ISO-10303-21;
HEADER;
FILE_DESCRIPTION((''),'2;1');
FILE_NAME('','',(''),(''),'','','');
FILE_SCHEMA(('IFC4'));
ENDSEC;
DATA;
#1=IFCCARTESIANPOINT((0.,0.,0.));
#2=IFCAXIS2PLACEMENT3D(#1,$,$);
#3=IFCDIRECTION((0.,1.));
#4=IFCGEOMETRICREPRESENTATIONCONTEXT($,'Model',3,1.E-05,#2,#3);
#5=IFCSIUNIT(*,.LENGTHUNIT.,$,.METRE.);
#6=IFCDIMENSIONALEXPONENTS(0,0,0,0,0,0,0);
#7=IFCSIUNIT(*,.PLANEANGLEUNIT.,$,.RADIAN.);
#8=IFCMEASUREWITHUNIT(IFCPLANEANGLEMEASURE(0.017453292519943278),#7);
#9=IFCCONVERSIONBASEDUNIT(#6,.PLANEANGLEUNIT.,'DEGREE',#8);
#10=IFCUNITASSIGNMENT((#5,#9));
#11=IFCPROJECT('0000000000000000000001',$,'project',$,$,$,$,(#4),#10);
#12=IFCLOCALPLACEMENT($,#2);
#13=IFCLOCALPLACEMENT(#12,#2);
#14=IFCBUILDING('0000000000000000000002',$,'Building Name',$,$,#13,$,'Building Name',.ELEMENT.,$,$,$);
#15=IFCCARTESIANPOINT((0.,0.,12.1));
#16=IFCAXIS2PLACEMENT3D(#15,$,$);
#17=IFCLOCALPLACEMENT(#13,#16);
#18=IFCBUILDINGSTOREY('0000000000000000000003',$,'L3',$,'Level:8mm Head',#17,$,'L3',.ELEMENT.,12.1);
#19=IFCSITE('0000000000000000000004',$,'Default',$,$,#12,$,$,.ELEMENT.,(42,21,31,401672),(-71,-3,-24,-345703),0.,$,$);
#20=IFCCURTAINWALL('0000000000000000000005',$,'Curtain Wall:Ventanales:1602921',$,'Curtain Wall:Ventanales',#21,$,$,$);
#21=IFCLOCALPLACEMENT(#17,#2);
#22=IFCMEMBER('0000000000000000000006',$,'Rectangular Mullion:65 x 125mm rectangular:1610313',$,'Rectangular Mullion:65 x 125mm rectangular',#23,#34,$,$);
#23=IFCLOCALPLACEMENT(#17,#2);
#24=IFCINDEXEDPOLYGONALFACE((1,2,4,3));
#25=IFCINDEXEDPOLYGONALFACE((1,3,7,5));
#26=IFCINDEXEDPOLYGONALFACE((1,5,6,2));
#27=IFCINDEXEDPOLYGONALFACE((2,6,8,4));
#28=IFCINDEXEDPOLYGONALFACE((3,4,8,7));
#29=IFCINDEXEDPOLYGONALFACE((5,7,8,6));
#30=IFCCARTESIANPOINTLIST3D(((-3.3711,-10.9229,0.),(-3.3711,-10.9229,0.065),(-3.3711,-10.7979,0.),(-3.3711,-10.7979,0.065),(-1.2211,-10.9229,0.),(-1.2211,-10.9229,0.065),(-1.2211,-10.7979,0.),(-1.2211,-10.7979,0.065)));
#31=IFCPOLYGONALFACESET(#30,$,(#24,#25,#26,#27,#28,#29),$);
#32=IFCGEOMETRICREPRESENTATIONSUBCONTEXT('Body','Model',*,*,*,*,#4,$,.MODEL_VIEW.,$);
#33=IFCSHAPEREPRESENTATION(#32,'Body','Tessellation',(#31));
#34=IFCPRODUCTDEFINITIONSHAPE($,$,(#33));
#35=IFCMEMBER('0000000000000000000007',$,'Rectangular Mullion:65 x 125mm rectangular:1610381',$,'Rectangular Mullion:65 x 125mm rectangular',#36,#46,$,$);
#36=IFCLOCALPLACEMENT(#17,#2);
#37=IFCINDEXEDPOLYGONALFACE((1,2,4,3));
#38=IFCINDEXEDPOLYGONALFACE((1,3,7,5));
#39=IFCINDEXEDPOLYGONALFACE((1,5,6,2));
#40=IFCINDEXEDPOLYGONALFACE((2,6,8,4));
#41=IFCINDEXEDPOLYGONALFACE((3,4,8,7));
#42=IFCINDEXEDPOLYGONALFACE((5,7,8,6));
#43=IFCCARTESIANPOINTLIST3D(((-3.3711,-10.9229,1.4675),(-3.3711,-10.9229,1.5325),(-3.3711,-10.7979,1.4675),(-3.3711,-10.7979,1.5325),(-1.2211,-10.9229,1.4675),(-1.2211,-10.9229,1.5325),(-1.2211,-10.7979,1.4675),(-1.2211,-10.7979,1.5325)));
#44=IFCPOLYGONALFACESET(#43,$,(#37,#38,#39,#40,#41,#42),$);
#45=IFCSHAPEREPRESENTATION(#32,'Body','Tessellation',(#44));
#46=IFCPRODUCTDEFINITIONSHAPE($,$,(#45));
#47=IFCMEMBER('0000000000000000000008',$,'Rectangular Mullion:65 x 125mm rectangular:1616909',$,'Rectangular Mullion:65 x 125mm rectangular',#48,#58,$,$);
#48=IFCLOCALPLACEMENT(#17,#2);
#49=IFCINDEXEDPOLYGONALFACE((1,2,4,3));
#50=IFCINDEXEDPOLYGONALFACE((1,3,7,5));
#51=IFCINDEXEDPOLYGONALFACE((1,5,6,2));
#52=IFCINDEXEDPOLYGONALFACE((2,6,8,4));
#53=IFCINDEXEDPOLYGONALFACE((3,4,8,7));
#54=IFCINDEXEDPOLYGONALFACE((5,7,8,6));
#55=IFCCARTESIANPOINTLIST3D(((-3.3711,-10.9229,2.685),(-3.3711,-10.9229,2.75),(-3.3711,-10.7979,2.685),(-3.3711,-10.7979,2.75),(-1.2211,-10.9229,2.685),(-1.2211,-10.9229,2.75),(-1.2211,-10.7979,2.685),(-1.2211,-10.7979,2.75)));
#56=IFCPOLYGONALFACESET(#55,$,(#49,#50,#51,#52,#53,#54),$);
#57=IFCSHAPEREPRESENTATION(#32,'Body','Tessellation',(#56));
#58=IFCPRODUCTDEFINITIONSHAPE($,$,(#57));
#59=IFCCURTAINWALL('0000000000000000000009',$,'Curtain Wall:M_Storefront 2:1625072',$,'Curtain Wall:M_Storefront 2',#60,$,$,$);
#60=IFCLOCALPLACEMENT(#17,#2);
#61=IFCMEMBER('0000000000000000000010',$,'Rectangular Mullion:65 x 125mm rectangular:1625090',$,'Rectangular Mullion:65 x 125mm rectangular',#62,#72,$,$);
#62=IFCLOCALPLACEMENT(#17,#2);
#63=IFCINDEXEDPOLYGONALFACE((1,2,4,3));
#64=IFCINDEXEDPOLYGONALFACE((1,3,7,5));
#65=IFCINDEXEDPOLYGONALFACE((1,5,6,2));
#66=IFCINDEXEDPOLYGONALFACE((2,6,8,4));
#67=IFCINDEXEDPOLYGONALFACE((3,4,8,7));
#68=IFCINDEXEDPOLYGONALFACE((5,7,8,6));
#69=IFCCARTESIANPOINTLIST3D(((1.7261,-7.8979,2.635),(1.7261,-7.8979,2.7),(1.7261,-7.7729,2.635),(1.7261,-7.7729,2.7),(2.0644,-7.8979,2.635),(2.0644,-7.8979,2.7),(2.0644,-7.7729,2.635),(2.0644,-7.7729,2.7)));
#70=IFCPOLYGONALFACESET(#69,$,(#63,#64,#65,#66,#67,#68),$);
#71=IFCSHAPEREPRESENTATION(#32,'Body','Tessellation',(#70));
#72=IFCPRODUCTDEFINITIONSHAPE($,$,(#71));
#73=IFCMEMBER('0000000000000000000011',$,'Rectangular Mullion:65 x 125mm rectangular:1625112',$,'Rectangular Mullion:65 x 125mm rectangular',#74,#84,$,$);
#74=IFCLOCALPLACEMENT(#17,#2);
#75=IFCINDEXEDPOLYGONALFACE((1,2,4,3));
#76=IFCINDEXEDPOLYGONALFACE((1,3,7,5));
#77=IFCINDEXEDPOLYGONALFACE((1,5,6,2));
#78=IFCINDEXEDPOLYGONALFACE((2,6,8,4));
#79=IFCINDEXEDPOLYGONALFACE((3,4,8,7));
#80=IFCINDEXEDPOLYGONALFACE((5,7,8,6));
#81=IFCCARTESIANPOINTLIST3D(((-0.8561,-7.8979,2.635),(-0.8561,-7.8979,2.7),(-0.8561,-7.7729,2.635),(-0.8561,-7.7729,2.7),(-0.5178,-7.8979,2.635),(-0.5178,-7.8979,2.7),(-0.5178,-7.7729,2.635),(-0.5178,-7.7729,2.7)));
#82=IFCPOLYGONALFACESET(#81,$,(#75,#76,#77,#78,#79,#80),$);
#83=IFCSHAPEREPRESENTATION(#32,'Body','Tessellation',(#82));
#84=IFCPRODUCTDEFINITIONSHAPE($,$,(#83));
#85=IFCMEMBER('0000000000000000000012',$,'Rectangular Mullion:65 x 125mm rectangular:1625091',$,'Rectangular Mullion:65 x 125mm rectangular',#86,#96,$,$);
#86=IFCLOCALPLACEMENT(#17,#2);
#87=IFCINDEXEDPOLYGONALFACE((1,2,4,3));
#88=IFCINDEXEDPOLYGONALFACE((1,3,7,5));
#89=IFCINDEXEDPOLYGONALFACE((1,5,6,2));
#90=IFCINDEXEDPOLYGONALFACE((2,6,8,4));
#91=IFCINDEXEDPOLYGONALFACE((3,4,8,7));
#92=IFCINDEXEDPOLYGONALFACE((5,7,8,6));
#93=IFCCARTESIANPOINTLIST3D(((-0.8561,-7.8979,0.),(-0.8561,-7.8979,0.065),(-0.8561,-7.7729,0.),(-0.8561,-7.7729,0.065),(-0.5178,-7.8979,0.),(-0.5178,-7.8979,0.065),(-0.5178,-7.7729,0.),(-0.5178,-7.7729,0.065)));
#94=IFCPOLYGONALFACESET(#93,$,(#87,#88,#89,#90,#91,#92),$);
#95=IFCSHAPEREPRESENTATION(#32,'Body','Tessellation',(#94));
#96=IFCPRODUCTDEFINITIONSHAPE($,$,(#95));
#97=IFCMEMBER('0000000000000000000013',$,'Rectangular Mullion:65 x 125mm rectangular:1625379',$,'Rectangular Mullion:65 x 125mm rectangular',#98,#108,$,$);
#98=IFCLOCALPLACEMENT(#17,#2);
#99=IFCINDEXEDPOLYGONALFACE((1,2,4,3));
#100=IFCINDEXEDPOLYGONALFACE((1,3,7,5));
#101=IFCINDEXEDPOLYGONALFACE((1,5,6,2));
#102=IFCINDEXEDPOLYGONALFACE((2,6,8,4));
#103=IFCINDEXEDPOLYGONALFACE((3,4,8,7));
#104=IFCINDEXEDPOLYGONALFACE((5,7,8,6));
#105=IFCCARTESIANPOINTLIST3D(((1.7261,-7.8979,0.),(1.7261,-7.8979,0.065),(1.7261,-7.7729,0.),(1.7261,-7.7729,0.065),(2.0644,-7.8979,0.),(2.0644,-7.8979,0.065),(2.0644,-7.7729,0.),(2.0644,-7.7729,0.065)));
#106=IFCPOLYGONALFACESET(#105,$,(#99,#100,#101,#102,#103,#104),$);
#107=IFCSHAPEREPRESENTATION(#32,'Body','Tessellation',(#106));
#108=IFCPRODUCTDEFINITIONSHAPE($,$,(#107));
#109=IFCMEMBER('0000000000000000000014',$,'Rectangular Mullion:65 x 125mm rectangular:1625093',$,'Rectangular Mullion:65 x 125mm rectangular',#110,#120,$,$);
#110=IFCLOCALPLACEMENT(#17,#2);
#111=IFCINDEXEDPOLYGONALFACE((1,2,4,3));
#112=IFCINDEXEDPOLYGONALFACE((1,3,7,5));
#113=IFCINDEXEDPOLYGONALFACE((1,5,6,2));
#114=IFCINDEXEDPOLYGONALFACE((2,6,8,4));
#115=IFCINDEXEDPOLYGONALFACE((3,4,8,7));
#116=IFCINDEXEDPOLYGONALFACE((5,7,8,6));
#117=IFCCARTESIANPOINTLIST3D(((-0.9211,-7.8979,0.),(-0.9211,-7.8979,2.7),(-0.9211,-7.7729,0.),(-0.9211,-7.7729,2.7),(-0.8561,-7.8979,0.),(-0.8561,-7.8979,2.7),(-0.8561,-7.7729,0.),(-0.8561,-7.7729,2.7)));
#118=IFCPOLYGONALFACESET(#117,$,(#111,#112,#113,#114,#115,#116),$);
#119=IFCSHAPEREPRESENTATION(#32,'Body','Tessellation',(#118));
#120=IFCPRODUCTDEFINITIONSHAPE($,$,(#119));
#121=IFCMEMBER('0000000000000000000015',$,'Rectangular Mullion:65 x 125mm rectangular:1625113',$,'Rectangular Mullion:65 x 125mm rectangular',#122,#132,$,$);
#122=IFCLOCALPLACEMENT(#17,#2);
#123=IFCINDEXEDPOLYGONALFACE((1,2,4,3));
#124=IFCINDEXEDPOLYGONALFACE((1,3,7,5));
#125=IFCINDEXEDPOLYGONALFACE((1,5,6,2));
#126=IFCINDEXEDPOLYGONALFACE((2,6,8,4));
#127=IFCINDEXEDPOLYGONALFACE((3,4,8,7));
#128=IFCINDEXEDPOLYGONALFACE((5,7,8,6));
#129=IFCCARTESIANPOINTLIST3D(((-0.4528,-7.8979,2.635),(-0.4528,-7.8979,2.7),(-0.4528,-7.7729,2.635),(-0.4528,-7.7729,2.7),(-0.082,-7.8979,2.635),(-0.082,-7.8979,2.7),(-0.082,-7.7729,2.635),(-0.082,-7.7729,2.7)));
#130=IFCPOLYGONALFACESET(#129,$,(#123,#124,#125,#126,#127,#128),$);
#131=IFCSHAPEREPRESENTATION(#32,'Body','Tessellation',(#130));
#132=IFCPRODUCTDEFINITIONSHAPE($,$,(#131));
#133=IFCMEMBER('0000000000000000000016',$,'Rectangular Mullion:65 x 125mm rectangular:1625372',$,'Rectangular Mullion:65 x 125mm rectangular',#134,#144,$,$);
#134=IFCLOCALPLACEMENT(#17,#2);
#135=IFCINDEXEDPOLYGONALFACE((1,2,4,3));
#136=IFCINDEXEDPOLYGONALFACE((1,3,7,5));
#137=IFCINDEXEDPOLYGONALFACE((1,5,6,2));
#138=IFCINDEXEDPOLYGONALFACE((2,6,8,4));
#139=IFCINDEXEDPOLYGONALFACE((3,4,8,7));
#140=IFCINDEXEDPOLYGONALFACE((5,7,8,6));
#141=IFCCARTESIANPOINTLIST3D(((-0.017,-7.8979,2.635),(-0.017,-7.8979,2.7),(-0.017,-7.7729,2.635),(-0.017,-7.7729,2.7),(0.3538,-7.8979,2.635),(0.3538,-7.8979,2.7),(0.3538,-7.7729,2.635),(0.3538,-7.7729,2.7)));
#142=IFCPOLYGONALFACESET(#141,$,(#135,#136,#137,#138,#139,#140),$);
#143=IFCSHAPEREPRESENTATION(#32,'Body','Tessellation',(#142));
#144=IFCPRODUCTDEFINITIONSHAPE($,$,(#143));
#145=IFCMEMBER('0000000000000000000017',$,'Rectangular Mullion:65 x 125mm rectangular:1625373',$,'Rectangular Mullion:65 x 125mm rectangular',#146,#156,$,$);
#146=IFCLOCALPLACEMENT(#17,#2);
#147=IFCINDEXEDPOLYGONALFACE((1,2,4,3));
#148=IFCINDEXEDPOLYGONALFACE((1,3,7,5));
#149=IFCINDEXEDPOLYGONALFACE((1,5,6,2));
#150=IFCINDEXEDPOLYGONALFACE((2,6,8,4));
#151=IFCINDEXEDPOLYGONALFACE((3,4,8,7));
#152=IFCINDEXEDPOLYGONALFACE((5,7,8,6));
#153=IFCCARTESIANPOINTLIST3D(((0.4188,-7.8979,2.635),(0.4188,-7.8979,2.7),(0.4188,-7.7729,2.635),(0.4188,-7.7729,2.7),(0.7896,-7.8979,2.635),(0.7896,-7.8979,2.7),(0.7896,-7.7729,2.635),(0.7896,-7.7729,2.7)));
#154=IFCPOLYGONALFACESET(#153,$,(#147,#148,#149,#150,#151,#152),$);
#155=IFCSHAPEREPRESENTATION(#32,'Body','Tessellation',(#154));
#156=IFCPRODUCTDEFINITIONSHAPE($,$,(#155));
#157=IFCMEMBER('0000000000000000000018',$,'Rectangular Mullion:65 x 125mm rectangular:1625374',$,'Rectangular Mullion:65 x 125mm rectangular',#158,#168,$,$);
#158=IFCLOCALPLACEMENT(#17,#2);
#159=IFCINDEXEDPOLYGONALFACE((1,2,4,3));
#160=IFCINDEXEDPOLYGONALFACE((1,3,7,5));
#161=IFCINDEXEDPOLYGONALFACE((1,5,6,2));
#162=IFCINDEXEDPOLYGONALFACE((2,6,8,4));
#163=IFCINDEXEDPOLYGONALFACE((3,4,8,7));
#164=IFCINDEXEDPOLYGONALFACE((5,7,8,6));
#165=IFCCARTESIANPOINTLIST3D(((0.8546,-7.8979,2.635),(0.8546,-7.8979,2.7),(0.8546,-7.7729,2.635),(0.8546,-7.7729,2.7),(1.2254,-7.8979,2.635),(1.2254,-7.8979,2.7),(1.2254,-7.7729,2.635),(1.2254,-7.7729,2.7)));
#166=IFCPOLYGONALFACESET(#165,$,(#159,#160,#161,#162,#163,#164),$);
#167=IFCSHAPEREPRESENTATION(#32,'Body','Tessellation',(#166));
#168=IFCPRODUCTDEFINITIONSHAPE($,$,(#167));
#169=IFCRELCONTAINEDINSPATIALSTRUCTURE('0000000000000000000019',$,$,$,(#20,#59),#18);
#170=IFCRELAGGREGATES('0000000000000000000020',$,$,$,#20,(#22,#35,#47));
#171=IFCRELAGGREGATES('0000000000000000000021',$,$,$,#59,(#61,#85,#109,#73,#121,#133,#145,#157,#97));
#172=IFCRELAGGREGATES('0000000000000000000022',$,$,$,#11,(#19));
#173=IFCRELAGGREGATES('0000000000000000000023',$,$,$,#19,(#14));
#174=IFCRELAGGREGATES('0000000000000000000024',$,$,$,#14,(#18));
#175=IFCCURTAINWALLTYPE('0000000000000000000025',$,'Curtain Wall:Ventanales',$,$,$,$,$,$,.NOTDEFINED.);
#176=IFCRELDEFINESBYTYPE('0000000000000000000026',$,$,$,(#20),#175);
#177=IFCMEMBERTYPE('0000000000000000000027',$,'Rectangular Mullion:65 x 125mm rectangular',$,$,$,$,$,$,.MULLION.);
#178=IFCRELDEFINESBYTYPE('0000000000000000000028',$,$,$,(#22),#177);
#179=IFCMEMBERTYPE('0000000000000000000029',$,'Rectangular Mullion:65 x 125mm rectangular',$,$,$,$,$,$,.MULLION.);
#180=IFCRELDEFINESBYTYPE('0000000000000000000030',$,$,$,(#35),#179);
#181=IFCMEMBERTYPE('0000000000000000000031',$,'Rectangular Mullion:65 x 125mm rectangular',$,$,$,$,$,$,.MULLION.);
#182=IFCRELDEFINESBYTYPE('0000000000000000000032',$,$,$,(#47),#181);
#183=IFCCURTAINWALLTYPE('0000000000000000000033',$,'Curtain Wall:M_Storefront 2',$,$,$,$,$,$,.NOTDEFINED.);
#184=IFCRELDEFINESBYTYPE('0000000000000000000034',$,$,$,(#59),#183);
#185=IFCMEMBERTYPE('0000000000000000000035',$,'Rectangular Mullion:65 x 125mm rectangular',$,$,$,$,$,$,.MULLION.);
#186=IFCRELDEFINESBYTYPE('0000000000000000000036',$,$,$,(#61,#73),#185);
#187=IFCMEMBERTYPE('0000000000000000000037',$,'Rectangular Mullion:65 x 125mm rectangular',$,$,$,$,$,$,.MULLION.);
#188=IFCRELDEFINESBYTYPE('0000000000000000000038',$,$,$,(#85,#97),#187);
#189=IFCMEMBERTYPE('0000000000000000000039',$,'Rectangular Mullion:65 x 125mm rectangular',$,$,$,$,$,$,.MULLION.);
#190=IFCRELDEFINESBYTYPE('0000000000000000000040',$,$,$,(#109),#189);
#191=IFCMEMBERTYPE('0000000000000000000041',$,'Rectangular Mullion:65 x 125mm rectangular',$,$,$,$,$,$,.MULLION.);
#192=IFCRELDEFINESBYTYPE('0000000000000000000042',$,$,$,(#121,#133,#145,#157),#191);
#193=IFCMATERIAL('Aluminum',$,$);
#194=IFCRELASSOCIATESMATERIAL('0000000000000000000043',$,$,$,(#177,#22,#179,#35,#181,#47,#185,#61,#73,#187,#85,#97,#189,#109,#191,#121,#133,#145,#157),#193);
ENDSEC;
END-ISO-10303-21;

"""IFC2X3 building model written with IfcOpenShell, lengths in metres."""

from ifc_helpers import new_model, entity, si_unit, converted_unit, direction, frame, origin, origin_2d_with_axis, place, context, subcontext, project, spatial, rectangle, extrude, source, transform, mapped, material, type_object, type_shapes, element, aggregate, save


model = new_model("IFC2X3")

# Units and contexts
model_context = context("Model", 3, precision=1e-05, world=origin(), true_north=direction((0.0, 1.0)))
body_context = subcontext(model_context, "Body", "Model", "MODEL_VIEW")
ifc_project = project(units=[si_unit("LENGTHUNIT", "METRE"), converted_unit("PLANEANGLEUNIT", "DEGREE", entity("IfcPlaneAngleMeasure", 0.017453292519943278), si_unit("PLANEANGLEUNIT", "RADIAN"), dimensions=[0, 0, 0, 0, 0, 0, 0])], contexts=[model_context])

# Site, building, storey
site_placement = place(None, origin())
site = spatial("IfcSite", under=ifc_project, at=site_placement, Name="Default", CompositionType="ELEMENT", RefLatitude=(42, 21, 31, 401672), RefLongitude=(-71, -3, -24, -345703), RefElevation=0.0)
building_placement = place(site_placement, origin())
building = spatial("IfcBuilding", under=site, at=building_placement, Name="Building Name", LongName="Building Name", CompositionType="ELEMENT")
storey_placement = place(building_placement, frame((0.0, 0.0, 12.1)))
storey = spatial("IfcBuildingStorey", under=building, at=storey_placement, Name="L3", ObjectType="Level:8mm Head", LongName="L3", CompositionType="ELEMENT", Elevation=12.1)

# Curtain walls, members
curtain_wall_type_1 = type_object("IfcCurtainWallType", Name="Curtain Wall:Ventanales", PredefinedType="NOTDEFINED")
curtain_wall_1_placement = place(storey_placement, frame((0.0, 0.0, -12.1)))
curtain_wall_1 = element("IfcCurtainWall", 1, at=curtain_wall_1_placement, inside=storey, type_object=curtain_wall_type_1, Name="Curtain Wall:Ventanales:1602921", ObjectType="Curtain Wall:Ventanales")
ifc_material_1 = material(Name="Aluminum")
member_type_1 = type_object("IfcMemberType", Name="Rectangular Mullion:65 x 125mm rectangular", PredefinedType="MULLION", material=ifc_material_1)
shared_shape_1 = source(origin(), body_context, "Body", "SweptSolid", [
    extrude(rectangle(XDim=0.065, YDim=0.125, at=origin_2d_with_axis()), frame((-0.0325, 0.0, -2.15), z_axis=(0.0, 0.0, 1.0), x_axis=(-1.0, 0.0, 0.0)), (0.0, 0.0, 1.0), 2.15),
])
type_shapes(member_type_1, [shared_shape_1])
member_1_placement = place(curtain_wall_1_placement, frame((-3.3711, -10.8604, 12.1), z_axis=(-1.0, 0.0, 0.0), x_axis=(0.0, 0.0, -1.0)))
member_1 = element("IfcMember", 2, at=member_1_placement, type_object=member_type_1, material=ifc_material_1, Name="Rectangular Mullion:65 x 125mm rectangular:1610313", ObjectType="Rectangular Mullion:65 x 125mm rectangular", context=body_context, shape_type="MappedRepresentation", body=[
    mapped(shared_shape_1, transform((0.0, 0.0, 0.0), scale=1.0)),
])
member_type_2 = type_object("IfcMemberType", Name="Rectangular Mullion:65 x 125mm rectangular", PredefinedType="MULLION", material=ifc_material_1)
shared_shape_2 = source(origin(), body_context, "Body", "SweptSolid", [
    extrude(rectangle(XDim=0.065, YDim=0.125, at=origin_2d_with_axis()), frame((0.0, 0.0, -2.15), z_axis=(0.0, 0.0, 1.0), x_axis=(-1.0, 0.0, 0.0)), (0.0, 0.0, 1.0), 2.15),
])
type_shapes(member_type_2, [shared_shape_2])
member_2_placement = place(curtain_wall_1_placement, frame((-1.2211, -10.8604, 13.6), z_axis=(1.0, 0.0, 0.0), x_axis=(0.0, 0.0, 1.0)))
member_2 = element("IfcMember", 3, at=member_2_placement, type_object=member_type_2, material=ifc_material_1, Name="Rectangular Mullion:65 x 125mm rectangular:1610381", ObjectType="Rectangular Mullion:65 x 125mm rectangular", context=body_context, shape_type="MappedRepresentation", body=[
    mapped(shared_shape_2, transform((0.0, 0.0, 0.0), scale=1.0)),
])
member_type_3 = type_object("IfcMemberType", Name="Rectangular Mullion:65 x 125mm rectangular", PredefinedType="MULLION", material=ifc_material_1)
shared_shape_3 = source(origin(), body_context, "Body", "SweptSolid", [
    extrude(rectangle(XDim=0.065, YDim=0.125, at=origin_2d_with_axis()), frame((-0.0325, 0.0, -2.15), z_axis=(0.0, 0.0, 1.0), x_axis=(-1.0, 0.0, 0.0)), (0.0, 0.0, 1.0), 2.15),
])
type_shapes(member_type_3, [shared_shape_3])
member_3_placement = place(curtain_wall_1_placement, frame((-1.2211, -10.8604, 14.85), z_axis=(1.0, 0.0, 0.0), x_axis=(0.0, 0.0, 1.0)))
member_3 = element("IfcMember", 4, at=member_3_placement, type_object=member_type_3, material=ifc_material_1, Name="Rectangular Mullion:65 x 125mm rectangular:1616909", ObjectType="Rectangular Mullion:65 x 125mm rectangular", context=body_context, shape_type="MappedRepresentation", body=[
    mapped(shared_shape_3, transform((0.0, 0.0, 0.0), scale=1.0)),
])
curtain_wall_type_2 = type_object("IfcCurtainWallType", Name="Curtain Wall:M_Storefront 2", PredefinedType="NOTDEFINED")
curtain_wall_2_placement = place(storey_placement, frame((0.0, 0.0, -12.1)))
curtain_wall_2 = element("IfcCurtainWall", 5, at=curtain_wall_2_placement, inside=storey, type_object=curtain_wall_type_2, Name="Curtain Wall:M_Storefront 2:1625072", ObjectType="Curtain Wall:M_Storefront 2")
member_type_4 = type_object("IfcMemberType", Name="Rectangular Mullion:65 x 125mm rectangular", PredefinedType="MULLION", material=ifc_material_1)
shared_shape_4 = source(origin(), body_context, "Body", "SweptSolid", [
    extrude(rectangle(XDim=0.065, YDim=0.125, at=origin_2d_with_axis()), frame((-0.0325, 0.0, -0.3383), z_axis=(0.0, 0.0, 1.0), x_axis=(-1.0, 0.0, 0.0)), (0.0, 0.0, 1.0), 0.3383),
])
type_shapes(member_type_4, [shared_shape_4])
member_4_placement = place(curtain_wall_2_placement, frame((2.0644, -7.8354, 14.8), z_axis=(1.0, 0.0, 0.0), x_axis=(0.0, 0.0, 1.0)))
member_4 = element("IfcMember", 6, at=member_4_placement, type_object=member_type_4, material=ifc_material_1, Name="Rectangular Mullion:65 x 125mm rectangular:1625090", ObjectType="Rectangular Mullion:65 x 125mm rectangular", context=body_context, shape_type="MappedRepresentation", body=[
    mapped(shared_shape_4, transform((0.0, 0.0, 0.0), scale=1.0)),
])
member_5_placement = place(curtain_wall_2_placement, frame((-0.5178, -7.8354, 14.8), z_axis=(1.0, 0.0, 0.0), x_axis=(0.0, 0.0, 1.0)))
member_5 = element("IfcMember", 7, at=member_5_placement, type_object=member_type_4, material=ifc_material_1, Name="Rectangular Mullion:65 x 125mm rectangular:1625112", ObjectType="Rectangular Mullion:65 x 125mm rectangular", context=body_context, shape_type="MappedRepresentation", body=[
    mapped(shared_shape_4, transform((0.0, 0.0, 0.0), scale=1.0)),
])
member_type_5 = type_object("IfcMemberType", Name="Rectangular Mullion:65 x 125mm rectangular", PredefinedType="MULLION", material=ifc_material_1)
shared_shape_5 = source(origin(), body_context, "Body", "SweptSolid", [
    extrude(rectangle(XDim=0.065, YDim=0.125, at=origin_2d_with_axis()), frame((-0.0325, 0.0, -0.3383), z_axis=(0.0, 0.0, 1.0), x_axis=(-1.0, 0.0, 0.0)), (0.0, 0.0, 1.0), 0.3383),
])
type_shapes(member_type_5, [shared_shape_5])
member_6_placement = place(curtain_wall_2_placement, frame((-0.8561, -7.8354, 12.1), z_axis=(-1.0, 0.0, 0.0), x_axis=(0.0, 0.0, -1.0)))
member_6 = element("IfcMember", 8, at=member_6_placement, type_object=member_type_5, material=ifc_material_1, Name="Rectangular Mullion:65 x 125mm rectangular:1625091", ObjectType="Rectangular Mullion:65 x 125mm rectangular", context=body_context, shape_type="MappedRepresentation", body=[
    mapped(shared_shape_5, transform((0.0, 0.0, 0.0), scale=1.0)),
])
member_7_placement = place(curtain_wall_2_placement, frame((1.7261, -7.8354, 12.1), z_axis=(-1.0, 0.0, 0.0), x_axis=(0.0, 0.0, -1.0)))
member_7 = element("IfcMember", 9, at=member_7_placement, type_object=member_type_5, material=ifc_material_1, Name="Rectangular Mullion:65 x 125mm rectangular:1625379", ObjectType="Rectangular Mullion:65 x 125mm rectangular", context=body_context, shape_type="MappedRepresentation", body=[
    mapped(shared_shape_5, transform((0.0, 0.0, 0.0), scale=1.0)),
])
member_type_6 = type_object("IfcMemberType", Name="Rectangular Mullion:65 x 125mm rectangular", PredefinedType="MULLION", material=ifc_material_1)
shared_shape_6 = source(origin(), body_context, "Body", "SweptSolid", [
    extrude(rectangle(XDim=0.065, YDim=0.125, at=origin_2d_with_axis()), frame((-0.0325, 0.0, -2.7), z_axis=(0.0, 0.0, 1.0), x_axis=(-1.0, 0.0, 0.0)), (0.0, 0.0, 1.0), 2.7),
])
type_shapes(member_type_6, [shared_shape_6])
member_8_placement = place(curtain_wall_2_placement, frame((-0.9211, -7.8354, 14.8), z_axis=(0.0, 0.0, 1.0), x_axis=(-1.0, 0.0, 0.0)))
member_8 = element("IfcMember", 10, at=member_8_placement, type_object=member_type_6, material=ifc_material_1, Name="Rectangular Mullion:65 x 125mm rectangular:1625093", ObjectType="Rectangular Mullion:65 x 125mm rectangular", context=body_context, shape_type="MappedRepresentation", body=[
    mapped(shared_shape_6, transform((0.0, 0.0, 0.0), scale=1.0)),
])
member_type_7 = type_object("IfcMemberType", Name="Rectangular Mullion:65 x 125mm rectangular", PredefinedType="MULLION", material=ifc_material_1)
shared_shape_7 = source(origin(), body_context, "Body", "SweptSolid", [
    extrude(rectangle(XDim=0.065, YDim=0.125, at=origin_2d_with_axis()), frame((-0.0325, 0.0, -0.3708), z_axis=(0.0, 0.0, 1.0), x_axis=(-1.0, 0.0, 0.0)), (0.0, 0.0, 1.0), 0.3708),
])
type_shapes(member_type_7, [shared_shape_7])
member_9_placement = place(curtain_wall_2_placement, frame((-0.082, -7.8354, 14.8), z_axis=(1.0, 0.0, 0.0), x_axis=(0.0, 0.0, 1.0)))
member_9 = element("IfcMember", 11, at=member_9_placement, type_object=member_type_7, material=ifc_material_1, Name="Rectangular Mullion:65 x 125mm rectangular:1625113", ObjectType="Rectangular Mullion:65 x 125mm rectangular", context=body_context, shape_type="MappedRepresentation", body=[
    mapped(shared_shape_7, transform((0.0, 0.0, 0.0), scale=1.0)),
])
member_10_placement = place(curtain_wall_2_placement, frame((0.3538, -7.8354, 14.8), z_axis=(1.0, 0.0, 0.0), x_axis=(0.0, 0.0, 1.0)))
member_10 = element("IfcMember", 12, at=member_10_placement, type_object=member_type_7, material=ifc_material_1, Name="Rectangular Mullion:65 x 125mm rectangular:1625372", ObjectType="Rectangular Mullion:65 x 125mm rectangular", context=body_context, shape_type="MappedRepresentation", body=[
    mapped(shared_shape_7, transform((0.0, 0.0, 0.0), scale=1.0)),
])
member_11_placement = place(curtain_wall_2_placement, frame((0.7896, -7.8354, 14.8), z_axis=(1.0, 0.0, 0.0), x_axis=(0.0, 0.0, 1.0)))
member_11 = element("IfcMember", 13, at=member_11_placement, type_object=member_type_7, material=ifc_material_1, Name="Rectangular Mullion:65 x 125mm rectangular:1625373", ObjectType="Rectangular Mullion:65 x 125mm rectangular", context=body_context, shape_type="MappedRepresentation", body=[
    mapped(shared_shape_7, transform((0.0, 0.0, 0.0), scale=1.0)),
])
member_12_placement = place(curtain_wall_2_placement, frame((1.2254, -7.8354, 14.8), z_axis=(1.0, 0.0, 0.0), x_axis=(0.0, 0.0, 1.0)))
member_12 = element("IfcMember", 14, at=member_12_placement, type_object=member_type_7, material=ifc_material_1, Name="Rectangular Mullion:65 x 125mm rectangular:1625374", ObjectType="Rectangular Mullion:65 x 125mm rectangular", context=body_context, shape_type="MappedRepresentation", body=[
    mapped(shared_shape_7, transform((0.0, 0.0, 0.0), scale=1.0)),
])

aggregate(curtain_wall_1, [member_1, member_2, member_3])

aggregate(curtain_wall_2, [member_4, member_6, member_8, member_5, member_9, member_10, member_11, member_12, member_7])

save(model, "model.ifc")
